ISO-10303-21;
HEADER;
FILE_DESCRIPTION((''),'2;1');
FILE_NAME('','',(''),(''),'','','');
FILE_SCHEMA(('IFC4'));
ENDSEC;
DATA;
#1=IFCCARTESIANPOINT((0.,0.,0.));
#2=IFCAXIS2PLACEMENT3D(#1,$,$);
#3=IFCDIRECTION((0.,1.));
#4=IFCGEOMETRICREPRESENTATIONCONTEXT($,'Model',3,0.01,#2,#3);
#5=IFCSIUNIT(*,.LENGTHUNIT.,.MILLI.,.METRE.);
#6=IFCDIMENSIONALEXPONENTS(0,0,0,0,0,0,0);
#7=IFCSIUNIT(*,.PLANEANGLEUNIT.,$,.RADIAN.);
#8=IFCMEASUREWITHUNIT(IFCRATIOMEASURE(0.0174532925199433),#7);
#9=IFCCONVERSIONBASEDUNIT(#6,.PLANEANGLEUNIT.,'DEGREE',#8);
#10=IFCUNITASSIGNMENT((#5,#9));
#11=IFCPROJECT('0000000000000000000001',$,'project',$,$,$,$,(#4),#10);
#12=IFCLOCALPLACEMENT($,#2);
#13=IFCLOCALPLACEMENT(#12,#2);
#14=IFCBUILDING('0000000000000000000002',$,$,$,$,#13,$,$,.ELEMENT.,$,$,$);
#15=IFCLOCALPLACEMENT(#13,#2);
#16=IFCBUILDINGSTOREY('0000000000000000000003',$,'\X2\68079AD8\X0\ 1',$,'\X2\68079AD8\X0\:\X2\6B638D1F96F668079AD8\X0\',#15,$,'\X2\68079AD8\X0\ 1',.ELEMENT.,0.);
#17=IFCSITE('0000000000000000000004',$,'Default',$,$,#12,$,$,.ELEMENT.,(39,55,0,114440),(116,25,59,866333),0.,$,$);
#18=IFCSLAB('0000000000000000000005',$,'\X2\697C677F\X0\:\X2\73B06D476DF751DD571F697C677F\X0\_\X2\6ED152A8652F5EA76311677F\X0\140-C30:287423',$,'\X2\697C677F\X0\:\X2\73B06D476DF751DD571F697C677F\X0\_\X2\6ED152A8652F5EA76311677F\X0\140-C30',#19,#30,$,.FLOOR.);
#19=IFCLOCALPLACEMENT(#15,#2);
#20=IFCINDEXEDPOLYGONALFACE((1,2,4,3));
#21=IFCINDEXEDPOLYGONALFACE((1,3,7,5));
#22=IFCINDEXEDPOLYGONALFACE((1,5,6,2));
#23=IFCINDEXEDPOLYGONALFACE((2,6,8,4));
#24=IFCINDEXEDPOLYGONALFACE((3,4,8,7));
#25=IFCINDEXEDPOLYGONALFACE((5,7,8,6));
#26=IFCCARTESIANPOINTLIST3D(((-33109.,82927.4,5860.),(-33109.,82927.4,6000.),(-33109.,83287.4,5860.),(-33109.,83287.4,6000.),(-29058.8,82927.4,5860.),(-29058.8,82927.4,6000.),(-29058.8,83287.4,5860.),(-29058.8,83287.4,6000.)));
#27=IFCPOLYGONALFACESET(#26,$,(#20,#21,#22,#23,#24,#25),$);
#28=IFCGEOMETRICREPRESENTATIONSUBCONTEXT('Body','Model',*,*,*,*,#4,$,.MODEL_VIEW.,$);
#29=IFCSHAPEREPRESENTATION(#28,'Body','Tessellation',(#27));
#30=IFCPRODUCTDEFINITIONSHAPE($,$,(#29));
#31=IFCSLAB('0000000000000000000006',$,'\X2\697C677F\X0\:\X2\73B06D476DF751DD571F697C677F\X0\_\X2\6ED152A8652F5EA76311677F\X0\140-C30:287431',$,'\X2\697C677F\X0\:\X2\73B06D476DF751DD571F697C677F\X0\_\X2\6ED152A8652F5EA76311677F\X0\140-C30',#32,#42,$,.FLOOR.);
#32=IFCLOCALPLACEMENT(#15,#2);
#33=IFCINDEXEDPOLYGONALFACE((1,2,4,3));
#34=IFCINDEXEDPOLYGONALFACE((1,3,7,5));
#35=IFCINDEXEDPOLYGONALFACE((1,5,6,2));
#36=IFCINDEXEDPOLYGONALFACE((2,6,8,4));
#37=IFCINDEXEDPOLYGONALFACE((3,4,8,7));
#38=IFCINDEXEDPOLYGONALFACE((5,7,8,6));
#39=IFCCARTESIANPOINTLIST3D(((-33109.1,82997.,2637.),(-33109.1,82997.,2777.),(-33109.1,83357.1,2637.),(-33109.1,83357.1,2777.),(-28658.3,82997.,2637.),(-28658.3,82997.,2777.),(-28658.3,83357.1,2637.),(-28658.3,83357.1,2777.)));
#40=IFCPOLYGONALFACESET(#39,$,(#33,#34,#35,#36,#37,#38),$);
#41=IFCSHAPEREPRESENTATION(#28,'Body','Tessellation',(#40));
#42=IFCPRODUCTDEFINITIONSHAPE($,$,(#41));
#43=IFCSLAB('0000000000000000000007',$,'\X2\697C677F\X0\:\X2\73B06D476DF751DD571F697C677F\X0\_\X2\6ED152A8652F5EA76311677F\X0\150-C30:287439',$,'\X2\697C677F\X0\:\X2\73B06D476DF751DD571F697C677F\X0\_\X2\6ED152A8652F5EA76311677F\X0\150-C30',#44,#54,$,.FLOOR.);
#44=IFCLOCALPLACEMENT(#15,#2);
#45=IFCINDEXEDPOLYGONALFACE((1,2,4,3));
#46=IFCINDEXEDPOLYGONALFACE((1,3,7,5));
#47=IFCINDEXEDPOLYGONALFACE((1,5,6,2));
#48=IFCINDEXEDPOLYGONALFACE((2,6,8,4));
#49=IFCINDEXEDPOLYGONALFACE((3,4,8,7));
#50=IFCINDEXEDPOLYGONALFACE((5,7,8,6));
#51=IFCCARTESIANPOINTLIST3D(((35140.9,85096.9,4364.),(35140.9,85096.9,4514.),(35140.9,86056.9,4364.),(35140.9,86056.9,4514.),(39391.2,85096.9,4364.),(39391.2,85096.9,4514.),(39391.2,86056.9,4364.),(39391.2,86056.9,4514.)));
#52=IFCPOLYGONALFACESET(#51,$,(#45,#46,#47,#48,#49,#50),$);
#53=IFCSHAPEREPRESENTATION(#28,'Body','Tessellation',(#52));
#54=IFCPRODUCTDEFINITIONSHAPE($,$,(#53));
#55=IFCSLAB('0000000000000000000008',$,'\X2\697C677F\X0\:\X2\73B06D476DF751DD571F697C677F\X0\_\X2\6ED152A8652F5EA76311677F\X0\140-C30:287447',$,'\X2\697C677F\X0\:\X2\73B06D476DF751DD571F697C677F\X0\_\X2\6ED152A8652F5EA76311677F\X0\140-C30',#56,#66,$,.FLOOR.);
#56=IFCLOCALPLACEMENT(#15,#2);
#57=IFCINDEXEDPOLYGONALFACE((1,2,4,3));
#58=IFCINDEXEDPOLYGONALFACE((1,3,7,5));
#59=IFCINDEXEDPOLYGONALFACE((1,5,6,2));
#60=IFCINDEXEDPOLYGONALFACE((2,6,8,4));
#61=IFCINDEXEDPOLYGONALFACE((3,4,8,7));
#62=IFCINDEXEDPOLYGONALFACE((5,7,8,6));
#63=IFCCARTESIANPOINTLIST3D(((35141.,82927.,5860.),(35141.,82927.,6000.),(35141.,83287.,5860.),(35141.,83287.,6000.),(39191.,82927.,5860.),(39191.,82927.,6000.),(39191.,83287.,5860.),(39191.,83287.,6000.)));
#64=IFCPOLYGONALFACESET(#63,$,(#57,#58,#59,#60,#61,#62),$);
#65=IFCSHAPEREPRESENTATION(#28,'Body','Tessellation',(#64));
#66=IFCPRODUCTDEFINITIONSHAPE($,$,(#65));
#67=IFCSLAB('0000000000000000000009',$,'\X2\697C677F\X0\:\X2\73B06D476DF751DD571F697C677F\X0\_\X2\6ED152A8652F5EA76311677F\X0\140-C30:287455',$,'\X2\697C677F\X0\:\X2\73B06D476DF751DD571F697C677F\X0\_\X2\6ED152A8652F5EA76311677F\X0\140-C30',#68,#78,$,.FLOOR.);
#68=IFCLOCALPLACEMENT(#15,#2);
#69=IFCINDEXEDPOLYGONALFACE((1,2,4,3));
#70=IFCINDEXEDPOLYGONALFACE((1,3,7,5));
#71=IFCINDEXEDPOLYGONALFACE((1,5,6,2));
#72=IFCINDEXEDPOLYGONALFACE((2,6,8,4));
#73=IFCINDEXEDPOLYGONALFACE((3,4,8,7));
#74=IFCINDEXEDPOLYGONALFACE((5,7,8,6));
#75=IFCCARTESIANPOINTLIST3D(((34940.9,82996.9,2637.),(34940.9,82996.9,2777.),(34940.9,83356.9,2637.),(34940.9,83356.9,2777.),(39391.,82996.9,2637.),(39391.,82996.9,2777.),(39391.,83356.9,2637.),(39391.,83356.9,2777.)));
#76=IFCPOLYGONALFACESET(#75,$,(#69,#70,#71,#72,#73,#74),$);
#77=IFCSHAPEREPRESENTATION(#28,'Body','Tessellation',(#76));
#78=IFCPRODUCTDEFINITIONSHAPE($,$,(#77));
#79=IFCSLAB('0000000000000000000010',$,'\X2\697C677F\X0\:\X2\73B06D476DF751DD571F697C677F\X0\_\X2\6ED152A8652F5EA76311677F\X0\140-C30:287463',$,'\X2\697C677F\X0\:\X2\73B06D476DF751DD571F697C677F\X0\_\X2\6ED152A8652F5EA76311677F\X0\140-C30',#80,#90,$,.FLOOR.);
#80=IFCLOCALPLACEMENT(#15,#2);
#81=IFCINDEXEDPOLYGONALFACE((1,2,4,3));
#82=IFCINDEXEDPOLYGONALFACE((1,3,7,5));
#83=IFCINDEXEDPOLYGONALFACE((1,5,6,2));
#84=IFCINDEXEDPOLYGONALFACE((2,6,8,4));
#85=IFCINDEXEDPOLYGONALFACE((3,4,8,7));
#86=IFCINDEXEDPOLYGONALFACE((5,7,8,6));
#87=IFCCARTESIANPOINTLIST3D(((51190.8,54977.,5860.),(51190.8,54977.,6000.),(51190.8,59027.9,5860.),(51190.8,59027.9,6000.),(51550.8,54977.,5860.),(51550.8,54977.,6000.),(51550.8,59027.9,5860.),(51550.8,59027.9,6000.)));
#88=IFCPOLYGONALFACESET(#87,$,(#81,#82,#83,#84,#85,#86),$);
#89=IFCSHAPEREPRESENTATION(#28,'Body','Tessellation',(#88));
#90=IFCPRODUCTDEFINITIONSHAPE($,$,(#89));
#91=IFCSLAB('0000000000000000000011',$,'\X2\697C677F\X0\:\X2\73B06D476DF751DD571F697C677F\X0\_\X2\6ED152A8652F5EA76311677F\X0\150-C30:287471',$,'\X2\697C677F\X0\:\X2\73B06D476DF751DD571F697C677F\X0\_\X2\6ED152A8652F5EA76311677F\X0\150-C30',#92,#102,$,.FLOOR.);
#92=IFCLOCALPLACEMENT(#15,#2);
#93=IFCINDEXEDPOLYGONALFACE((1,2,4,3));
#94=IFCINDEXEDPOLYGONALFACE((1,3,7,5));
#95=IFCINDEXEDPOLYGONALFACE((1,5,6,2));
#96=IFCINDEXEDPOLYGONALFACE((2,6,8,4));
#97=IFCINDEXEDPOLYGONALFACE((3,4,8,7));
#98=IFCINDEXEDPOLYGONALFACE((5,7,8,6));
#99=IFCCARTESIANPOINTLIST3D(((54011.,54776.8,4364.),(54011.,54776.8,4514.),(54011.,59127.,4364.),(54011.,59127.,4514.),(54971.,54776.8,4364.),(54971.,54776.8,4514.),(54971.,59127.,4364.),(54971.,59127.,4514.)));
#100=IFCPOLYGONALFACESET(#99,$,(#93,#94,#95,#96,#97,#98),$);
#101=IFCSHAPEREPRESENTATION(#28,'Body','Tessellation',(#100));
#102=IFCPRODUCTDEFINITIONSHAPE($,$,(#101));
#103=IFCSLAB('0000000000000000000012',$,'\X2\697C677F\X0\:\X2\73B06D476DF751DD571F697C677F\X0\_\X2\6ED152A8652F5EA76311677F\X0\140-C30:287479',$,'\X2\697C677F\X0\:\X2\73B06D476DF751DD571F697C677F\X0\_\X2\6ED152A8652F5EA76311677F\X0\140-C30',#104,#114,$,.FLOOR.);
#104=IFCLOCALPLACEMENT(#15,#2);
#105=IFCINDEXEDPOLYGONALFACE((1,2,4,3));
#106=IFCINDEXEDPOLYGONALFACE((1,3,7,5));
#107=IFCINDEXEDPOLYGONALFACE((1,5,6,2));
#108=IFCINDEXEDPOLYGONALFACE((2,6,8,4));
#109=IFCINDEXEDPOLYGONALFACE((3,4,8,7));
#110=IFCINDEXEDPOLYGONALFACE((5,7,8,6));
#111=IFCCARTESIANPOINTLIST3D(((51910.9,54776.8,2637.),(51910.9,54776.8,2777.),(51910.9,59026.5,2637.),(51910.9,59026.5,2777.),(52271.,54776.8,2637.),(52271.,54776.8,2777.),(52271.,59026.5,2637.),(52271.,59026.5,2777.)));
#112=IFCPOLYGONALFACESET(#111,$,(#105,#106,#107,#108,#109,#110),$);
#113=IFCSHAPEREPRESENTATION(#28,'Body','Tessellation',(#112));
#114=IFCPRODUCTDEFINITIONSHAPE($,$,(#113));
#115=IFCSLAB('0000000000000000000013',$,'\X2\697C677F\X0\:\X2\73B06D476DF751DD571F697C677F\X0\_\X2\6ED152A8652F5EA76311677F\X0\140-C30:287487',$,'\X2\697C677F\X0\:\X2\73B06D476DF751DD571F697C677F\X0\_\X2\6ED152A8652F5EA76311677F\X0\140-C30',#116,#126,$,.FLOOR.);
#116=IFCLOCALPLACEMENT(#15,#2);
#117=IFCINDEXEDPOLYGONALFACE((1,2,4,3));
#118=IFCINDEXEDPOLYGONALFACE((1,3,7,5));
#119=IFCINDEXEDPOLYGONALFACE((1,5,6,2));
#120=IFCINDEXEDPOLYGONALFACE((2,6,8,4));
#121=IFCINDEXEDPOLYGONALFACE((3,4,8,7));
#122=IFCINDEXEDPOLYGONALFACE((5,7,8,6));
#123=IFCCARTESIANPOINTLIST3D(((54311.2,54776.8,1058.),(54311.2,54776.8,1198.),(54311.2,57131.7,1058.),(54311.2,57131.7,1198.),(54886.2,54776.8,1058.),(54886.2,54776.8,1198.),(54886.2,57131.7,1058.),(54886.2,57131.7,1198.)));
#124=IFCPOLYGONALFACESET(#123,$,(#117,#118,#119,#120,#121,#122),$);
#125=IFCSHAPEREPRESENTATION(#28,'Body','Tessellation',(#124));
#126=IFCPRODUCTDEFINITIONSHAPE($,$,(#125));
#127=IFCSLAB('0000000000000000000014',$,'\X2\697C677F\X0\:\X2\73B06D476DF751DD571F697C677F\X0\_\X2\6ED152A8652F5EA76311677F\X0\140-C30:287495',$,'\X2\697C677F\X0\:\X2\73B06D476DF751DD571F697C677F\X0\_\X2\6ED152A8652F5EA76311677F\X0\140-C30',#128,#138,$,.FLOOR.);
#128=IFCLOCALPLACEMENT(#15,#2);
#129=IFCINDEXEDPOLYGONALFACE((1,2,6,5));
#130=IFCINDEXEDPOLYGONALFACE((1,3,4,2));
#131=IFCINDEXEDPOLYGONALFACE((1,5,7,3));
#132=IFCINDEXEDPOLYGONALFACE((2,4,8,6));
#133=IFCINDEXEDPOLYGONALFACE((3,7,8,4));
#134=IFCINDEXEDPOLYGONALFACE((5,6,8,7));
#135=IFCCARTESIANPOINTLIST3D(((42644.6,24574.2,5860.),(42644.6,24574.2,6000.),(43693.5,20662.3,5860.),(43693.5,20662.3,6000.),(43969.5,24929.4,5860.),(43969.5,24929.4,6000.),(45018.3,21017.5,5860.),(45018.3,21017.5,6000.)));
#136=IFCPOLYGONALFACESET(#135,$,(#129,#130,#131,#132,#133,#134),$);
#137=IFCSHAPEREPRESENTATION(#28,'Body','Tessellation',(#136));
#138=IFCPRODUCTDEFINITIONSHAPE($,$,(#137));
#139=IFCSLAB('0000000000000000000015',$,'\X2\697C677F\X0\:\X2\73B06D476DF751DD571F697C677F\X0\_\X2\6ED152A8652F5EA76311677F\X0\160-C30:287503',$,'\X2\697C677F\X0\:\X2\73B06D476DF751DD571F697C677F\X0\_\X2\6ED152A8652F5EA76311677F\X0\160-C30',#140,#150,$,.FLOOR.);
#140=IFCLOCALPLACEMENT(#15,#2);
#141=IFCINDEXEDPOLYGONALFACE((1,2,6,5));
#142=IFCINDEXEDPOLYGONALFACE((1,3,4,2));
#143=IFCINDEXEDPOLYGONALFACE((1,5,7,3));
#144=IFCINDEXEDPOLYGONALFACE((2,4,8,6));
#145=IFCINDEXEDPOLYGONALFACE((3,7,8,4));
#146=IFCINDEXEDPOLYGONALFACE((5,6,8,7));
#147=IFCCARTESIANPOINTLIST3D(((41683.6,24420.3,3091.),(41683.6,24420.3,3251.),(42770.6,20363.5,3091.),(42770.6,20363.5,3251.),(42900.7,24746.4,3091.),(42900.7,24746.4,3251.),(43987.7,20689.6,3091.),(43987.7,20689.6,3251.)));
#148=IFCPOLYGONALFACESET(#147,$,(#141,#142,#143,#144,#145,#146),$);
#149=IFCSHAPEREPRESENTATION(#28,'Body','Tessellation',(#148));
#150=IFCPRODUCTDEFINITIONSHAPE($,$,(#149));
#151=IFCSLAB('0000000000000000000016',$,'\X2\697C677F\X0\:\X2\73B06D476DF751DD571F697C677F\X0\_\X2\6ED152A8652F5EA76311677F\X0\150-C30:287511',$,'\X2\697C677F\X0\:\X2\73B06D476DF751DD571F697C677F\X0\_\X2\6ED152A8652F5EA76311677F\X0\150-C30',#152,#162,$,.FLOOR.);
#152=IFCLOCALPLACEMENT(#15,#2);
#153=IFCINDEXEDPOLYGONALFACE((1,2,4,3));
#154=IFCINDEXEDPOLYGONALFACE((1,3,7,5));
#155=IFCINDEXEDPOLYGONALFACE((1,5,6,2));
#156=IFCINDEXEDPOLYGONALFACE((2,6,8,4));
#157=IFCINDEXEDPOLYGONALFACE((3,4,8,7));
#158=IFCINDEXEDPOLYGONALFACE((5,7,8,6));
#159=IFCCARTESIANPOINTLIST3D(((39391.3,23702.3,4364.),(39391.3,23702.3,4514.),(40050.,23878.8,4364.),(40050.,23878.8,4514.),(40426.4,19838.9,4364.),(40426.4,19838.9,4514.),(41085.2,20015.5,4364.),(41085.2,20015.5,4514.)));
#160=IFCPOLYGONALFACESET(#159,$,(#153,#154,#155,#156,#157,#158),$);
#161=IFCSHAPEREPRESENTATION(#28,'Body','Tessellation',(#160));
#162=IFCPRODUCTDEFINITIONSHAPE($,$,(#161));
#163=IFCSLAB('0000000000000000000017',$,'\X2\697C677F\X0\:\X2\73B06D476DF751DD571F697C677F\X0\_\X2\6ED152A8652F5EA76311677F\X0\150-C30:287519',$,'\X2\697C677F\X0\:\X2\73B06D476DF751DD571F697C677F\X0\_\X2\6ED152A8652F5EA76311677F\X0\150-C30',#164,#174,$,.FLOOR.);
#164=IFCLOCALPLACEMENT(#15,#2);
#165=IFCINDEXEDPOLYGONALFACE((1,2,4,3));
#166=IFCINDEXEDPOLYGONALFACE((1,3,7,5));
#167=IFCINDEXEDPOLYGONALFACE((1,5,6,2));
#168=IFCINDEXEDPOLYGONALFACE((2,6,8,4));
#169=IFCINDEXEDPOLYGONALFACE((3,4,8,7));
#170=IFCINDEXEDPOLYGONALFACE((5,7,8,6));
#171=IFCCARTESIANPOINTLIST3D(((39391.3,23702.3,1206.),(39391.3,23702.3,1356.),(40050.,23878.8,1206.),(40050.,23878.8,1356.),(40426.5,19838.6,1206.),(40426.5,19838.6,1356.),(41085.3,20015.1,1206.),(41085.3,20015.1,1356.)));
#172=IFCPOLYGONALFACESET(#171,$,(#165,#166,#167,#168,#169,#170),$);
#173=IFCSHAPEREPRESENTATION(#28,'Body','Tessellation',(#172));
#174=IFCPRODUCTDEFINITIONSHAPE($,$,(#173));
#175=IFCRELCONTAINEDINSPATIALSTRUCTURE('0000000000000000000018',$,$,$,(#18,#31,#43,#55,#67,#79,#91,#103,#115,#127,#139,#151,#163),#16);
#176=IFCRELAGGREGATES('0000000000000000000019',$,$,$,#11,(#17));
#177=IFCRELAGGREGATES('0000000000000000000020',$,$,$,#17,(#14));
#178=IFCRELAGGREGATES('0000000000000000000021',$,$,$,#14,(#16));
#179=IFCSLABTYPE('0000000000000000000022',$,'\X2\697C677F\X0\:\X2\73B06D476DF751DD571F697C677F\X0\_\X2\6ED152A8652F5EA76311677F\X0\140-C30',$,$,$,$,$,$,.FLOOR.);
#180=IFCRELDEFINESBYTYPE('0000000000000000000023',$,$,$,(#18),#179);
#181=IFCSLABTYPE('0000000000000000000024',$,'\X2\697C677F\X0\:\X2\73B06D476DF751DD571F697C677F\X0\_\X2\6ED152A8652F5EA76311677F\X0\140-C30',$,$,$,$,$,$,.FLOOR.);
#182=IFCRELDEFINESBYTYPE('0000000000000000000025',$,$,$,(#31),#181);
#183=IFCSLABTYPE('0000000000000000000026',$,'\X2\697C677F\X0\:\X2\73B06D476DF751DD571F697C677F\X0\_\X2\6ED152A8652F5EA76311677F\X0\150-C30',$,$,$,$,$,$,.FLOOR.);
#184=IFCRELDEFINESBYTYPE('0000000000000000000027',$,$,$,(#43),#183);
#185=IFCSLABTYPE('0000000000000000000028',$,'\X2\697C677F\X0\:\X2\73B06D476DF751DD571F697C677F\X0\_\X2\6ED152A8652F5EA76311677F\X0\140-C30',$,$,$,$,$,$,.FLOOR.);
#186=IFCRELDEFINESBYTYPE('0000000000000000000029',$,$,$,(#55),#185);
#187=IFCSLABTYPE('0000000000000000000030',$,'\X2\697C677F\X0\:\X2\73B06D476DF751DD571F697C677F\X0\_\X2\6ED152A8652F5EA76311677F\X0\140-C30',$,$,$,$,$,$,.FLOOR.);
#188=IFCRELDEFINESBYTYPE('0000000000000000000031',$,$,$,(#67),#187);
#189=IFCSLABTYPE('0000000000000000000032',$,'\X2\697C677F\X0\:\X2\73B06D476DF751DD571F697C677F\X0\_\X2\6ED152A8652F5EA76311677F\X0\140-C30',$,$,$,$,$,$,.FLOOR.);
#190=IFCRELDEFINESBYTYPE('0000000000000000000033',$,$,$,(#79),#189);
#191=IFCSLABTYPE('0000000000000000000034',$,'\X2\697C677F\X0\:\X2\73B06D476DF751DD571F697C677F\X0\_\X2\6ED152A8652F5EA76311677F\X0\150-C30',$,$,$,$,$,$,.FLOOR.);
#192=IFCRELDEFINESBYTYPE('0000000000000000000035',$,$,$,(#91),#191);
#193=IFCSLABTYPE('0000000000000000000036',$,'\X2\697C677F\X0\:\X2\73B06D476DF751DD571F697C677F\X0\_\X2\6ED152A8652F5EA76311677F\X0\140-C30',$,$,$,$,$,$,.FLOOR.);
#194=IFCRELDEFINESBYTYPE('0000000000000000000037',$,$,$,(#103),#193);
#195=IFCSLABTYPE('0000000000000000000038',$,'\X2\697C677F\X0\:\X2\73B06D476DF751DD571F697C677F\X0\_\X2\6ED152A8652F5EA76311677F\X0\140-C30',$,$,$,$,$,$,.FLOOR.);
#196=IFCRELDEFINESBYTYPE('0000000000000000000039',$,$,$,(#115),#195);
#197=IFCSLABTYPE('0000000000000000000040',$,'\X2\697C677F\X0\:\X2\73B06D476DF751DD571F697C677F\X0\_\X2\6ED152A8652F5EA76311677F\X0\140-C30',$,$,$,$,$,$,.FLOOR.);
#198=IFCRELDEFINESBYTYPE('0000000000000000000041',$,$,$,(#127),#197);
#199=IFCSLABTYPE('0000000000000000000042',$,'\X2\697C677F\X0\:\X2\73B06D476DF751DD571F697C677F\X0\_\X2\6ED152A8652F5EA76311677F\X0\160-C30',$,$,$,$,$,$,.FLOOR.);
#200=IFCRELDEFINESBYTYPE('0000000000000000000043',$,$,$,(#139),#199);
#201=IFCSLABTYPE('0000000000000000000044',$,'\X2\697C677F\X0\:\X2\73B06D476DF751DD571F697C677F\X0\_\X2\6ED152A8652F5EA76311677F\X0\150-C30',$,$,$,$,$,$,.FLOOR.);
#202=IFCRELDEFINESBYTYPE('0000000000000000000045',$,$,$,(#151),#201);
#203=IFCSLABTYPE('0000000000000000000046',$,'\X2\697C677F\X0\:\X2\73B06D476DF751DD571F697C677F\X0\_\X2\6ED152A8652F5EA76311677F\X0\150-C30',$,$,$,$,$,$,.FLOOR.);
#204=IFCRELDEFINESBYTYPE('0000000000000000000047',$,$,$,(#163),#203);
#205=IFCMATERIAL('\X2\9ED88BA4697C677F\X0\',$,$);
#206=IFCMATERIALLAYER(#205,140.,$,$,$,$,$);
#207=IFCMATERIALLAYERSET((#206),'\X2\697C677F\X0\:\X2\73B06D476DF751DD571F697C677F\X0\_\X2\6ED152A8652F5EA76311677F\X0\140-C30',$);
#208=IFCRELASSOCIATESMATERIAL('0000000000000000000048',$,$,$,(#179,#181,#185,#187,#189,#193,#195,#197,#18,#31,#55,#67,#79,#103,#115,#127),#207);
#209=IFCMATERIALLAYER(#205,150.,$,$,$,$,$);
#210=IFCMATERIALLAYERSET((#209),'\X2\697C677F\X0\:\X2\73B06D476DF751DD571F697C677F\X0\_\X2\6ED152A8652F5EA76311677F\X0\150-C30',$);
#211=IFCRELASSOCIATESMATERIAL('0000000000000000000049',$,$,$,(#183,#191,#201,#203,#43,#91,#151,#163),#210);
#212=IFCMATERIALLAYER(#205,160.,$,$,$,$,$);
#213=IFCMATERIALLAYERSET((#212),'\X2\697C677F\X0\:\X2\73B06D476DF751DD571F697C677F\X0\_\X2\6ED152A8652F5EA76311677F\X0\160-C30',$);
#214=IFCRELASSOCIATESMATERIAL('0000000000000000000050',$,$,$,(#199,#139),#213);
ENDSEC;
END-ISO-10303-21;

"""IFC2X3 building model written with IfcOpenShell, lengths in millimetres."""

from ifc_helpers import new_model, entity, si_unit, converted_unit, direction, frame, frame_2d, origin, origin_2d_with_axis, place, context, subcontext, project, spatial, polyline, rectangle, outline, extrude, material, layer, layer_set, layer_usage, type_object, element, save


model = new_model("IFC2X3")

# Units and contexts
model_context = context("Model", 3, precision=0.01, world=origin(), true_north=direction((0.0, 1.0)))
body_context = subcontext(model_context, "Body", "Model", "MODEL_VIEW")
ifc_project = project(units=[si_unit("LENGTHUNIT", "METRE", prefix="MILLI"), converted_unit("PLANEANGLEUNIT", "DEGREE", entity("IfcRatioMeasure", 0.0174532925199433), si_unit("PLANEANGLEUNIT", "RADIAN"), dimensions=[0, 0, 0, 0, 0, 0, 0])], contexts=[model_context])

# Site, building, storey
site_placement = place(None, origin())
site = spatial("IfcSite", under=ifc_project, at=site_placement, Name="Default", CompositionType="ELEMENT", RefLatitude=(39, 55, 0, 114440), RefLongitude=(116, 25, 59, 866333), RefElevation=0.0)
building_placement = place(site_placement, origin())
building = spatial("IfcBuilding", under=site, at=building_placement, CompositionType="ELEMENT")
storey_placement = place(building_placement, origin())
storey = spatial("IfcBuildingStorey", under=building, at=storey_placement, Name="标高 1", ObjectType="标高:正负零标高", LongName="标高 1", CompositionType="ELEMENT", Elevation=0.0)

# Slabs
ifc_material = material(Name="默认楼板")
ifc_layer_1 = layer(ifc_material, 140.0)
ifc_layer_set_1 = layer_set([ifc_layer_1], Name="楼板:现浇混凝土楼板_滑动支座挑板140-C30")
ifc_layer_usage_1 = layer_usage(ifc_layer_set_1, "AXIS3", "POSITIVE", 0.0)
slab_type_1 = type_object("IfcSlabType", Name="楼板:现浇混凝土楼板_滑动支座挑板140-C30", PredefinedType="FLOOR", material=ifc_layer_set_1)
slab_1_placement = place(building_placement, origin())
element("IfcSlab", 1, at=slab_1_placement, inside=storey, type_object=slab_type_1, material=ifc_layer_usage_1, Name="楼板:现浇混凝土楼板_滑动支座挑板140-C30:287423", ObjectType="楼板:现浇混凝土楼板_滑动支座挑板140-C30", PredefinedType="FLOOR", context=body_context, shape_type="SweptSolid", body=[
    extrude(rectangle(XDim=360.0, YDim=4050.2, at=frame_2d((0.0, 0.0), x_axis=(1.0, 0.0))), frame((-31083.9, 83107.4, 6000.0), z_axis=(0.0, 0.0, -1.0), x_axis=(0.0, 1.0, 0.0)), (0.0, 0.0, 1.0), 140.0),
])
ifc_layer_usage_2 = layer_usage(ifc_layer_set_1, "AXIS3", "POSITIVE", 0.0)
slab_type_2 = type_object("IfcSlabType", Name="楼板:现浇混凝土楼板_滑动支座挑板140-C30", PredefinedType="FLOOR", material=ifc_layer_set_1)
slab_2_placement = place(building_placement, origin())
element("IfcSlab", 2, at=slab_2_placement, inside=storey, type_object=slab_type_2, material=ifc_layer_usage_2, Name="楼板:现浇混凝土楼板_滑动支座挑板140-C30:287431", ObjectType="楼板:现浇混凝土楼板_滑动支座挑板140-C30", PredefinedType="FLOOR", context=body_context, shape_type="SweptSolid", body=[
    extrude(rectangle(XDim=360.2, YDim=4450.8, at=frame_2d((0.0, 0.0), x_axis=(1.0, 0.0))), frame((-30883.7, 83177.0, 2777.0), z_axis=(0.0, 0.0, -1.0), x_axis=(0.0, 1.0, 0.0)), (0.0, 0.0, 1.0), 140.0),
])
ifc_layer_2 = layer(ifc_material, 150.0)
ifc_layer_set_2 = layer_set([ifc_layer_2], Name="楼板:现浇混凝土楼板_滑动支座挑板150-C30")
ifc_layer_usage_3 = layer_usage(ifc_layer_set_2, "AXIS3", "POSITIVE", 0.0)
slab_type_3 = type_object("IfcSlabType", Name="楼板:现浇混凝土楼板_滑动支座挑板150-C30", PredefinedType="FLOOR", material=ifc_layer_set_2)
slab_3_placement = place(building_placement, origin())
element("IfcSlab", 3, at=slab_3_placement, inside=storey, type_object=slab_type_3, material=ifc_layer_usage_3, Name="楼板:现浇混凝土楼板_滑动支座挑板150-C30:287439", ObjectType="楼板:现浇混凝土楼板_滑动支座挑板150-C30", PredefinedType="FLOOR", context=body_context, shape_type="SweptSolid", body=[
    extrude(rectangle(XDim=960.0, YDim=4250.3, at=frame_2d((0.0, 0.0), x_axis=(1.0, 0.0))), frame((37266.0, 85576.9, 4514.0), z_axis=(0.0, 0.0, -1.0), x_axis=(0.0, 1.0, 0.0)), (0.0, 0.0, 1.0), 150.0),
])
ifc_layer_usage_4 = layer_usage(ifc_layer_set_1, "AXIS3", "POSITIVE", 0.0)
slab_type_4 = type_object("IfcSlabType", Name="楼板:现浇混凝土楼板_滑动支座挑板140-C30", PredefinedType="FLOOR", material=ifc_layer_set_1)
slab_4_placement = place(building_placement, origin())
element("IfcSlab", 4, at=slab_4_placement, inside=storey, type_object=slab_type_4, material=ifc_layer_usage_4, Name="楼板:现浇混凝土楼板_滑动支座挑板140-C30:287447", ObjectType="楼板:现浇混凝土楼板_滑动支座挑板140-C30", PredefinedType="FLOOR", context=body_context, shape_type="SweptSolid", body=[
    extrude(rectangle(XDim=360.0, YDim=4050.0, at=origin_2d_with_axis()), frame((37166.0, 83107.0, 6000.0), z_axis=(0.0, 0.0, -1.0), x_axis=(0.0, 1.0, 0.0)), (0.0, 0.0, 1.0), 140.0),
])
ifc_layer_usage_5 = layer_usage(ifc_layer_set_1, "AXIS3", "POSITIVE", 0.0)
slab_type_5 = type_object("IfcSlabType", Name="楼板:现浇混凝土楼板_滑动支座挑板140-C30", PredefinedType="FLOOR", material=ifc_layer_set_1)
slab_5_placement = place(building_placement, origin())
element("IfcSlab", 5, at=slab_5_placement, inside=storey, type_object=slab_type_5, material=ifc_layer_usage_5, Name="楼板:现浇混凝土楼板_滑动支座挑板140-C30:287455", ObjectType="楼板:现浇混凝土楼板_滑动支座挑板140-C30", PredefinedType="FLOOR", context=body_context, shape_type="SweptSolid", body=[
    extrude(rectangle(XDim=360.0, YDim=4450.1, at=frame_2d((0.0, 0.0), x_axis=(1.0, 0.0))), frame((37165.9, 83176.9, 2777.0), z_axis=(0.0, 0.0, -1.0), x_axis=(0.0, 1.0, 0.0)), (0.0, 0.0, 1.0), 140.0),
])
ifc_layer_usage_6 = layer_usage(ifc_layer_set_1, "AXIS3", "POSITIVE", 0.0)
slab_type_6 = type_object("IfcSlabType", Name="楼板:现浇混凝土楼板_滑动支座挑板140-C30", PredefinedType="FLOOR", material=ifc_layer_set_1)
slab_6_placement = place(building_placement, origin())
element("IfcSlab", 6, at=slab_6_placement, inside=storey, type_object=slab_type_6, material=ifc_layer_usage_6, Name="楼板:现浇混凝土楼板_滑动支座挑板140-C30:287463", ObjectType="楼板:现浇混凝土楼板_滑动支座挑板140-C30", PredefinedType="FLOOR", context=body_context, shape_type="SweptSolid", body=[
    extrude(rectangle(XDim=4050.9, YDim=360.0, at=frame_2d((0.0, 0.0), x_axis=(1.0, 0.0))), frame((51370.8, 57002.4, 6000.0), z_axis=(0.0, 0.0, -1.0), x_axis=(0.0, 1.0, 0.0)), (0.0, 0.0, 1.0), 140.0),
])
ifc_layer_usage_7 = layer_usage(ifc_layer_set_2, "AXIS3", "POSITIVE", 0.0)
slab_type_7 = type_object("IfcSlabType", Name="楼板:现浇混凝土楼板_滑动支座挑板150-C30", PredefinedType="FLOOR", material=ifc_layer_set_2)
slab_7_placement = place(building_placement, origin())
element("IfcSlab", 7, at=slab_7_placement, inside=storey, type_object=slab_type_7, material=ifc_layer_usage_7, Name="楼板:现浇混凝土楼板_滑动支座挑板150-C30:287471", ObjectType="楼板:现浇混凝土楼板_滑动支座挑板150-C30", PredefinedType="FLOOR", context=body_context, shape_type="SweptSolid", body=[
    extrude(rectangle(XDim=4350.2, YDim=960.0, at=origin_2d_with_axis()), frame((54491.0, 56951.9, 4514.0), z_axis=(0.0, 0.0, -1.0), x_axis=(0.0, 1.0, 0.0)), (0.0, 0.0, 1.0), 150.0),
])
ifc_layer_usage_8 = layer_usage(ifc_layer_set_1, "AXIS3", "POSITIVE", 0.0)
slab_type_8 = type_object("IfcSlabType", Name="楼板:现浇混凝土楼板_滑动支座挑板140-C30", PredefinedType="FLOOR", material=ifc_layer_set_1)
slab_8_placement = place(building_placement, origin())
element("IfcSlab", 8, at=slab_8_placement, inside=storey, type_object=slab_type_8, material=ifc_layer_usage_8, Name="楼板:现浇混凝土楼板_滑动支座挑板140-C30:287479", ObjectType="楼板:现浇混凝土楼板_滑动支座挑板140-C30", PredefinedType="FLOOR", context=body_context, shape_type="SweptSolid", body=[
    extrude(rectangle(XDim=4249.7, YDim=360.1, at=frame_2d((0.0, 0.0), x_axis=(1.0, 0.0))), frame((52091.0, 56901.7, 2777.0), z_axis=(0.0, 0.0, -1.0), x_axis=(0.0, 1.0, 0.0)), (0.0, 0.0, 1.0), 140.0),
])
ifc_layer_usage_9 = layer_usage(ifc_layer_set_1, "AXIS3", "POSITIVE", 0.0)
slab_type_9 = type_object("IfcSlabType", Name="楼板:现浇混凝土楼板_滑动支座挑板140-C30", PredefinedType="FLOOR", material=ifc_layer_set_1)
slab_9_placement = place(building_placement, origin())
element("IfcSlab", 9, at=slab_9_placement, inside=storey, type_object=slab_type_9, material=ifc_layer_usage_9, Name="楼板:现浇混凝土楼板_滑动支座挑板140-C30:287487", ObjectType="楼板:现浇混凝土楼板_滑动支座挑板140-C30", PredefinedType="FLOOR", context=body_context, shape_type="SweptSolid", body=[
    extrude(rectangle(XDim=2354.8, YDim=575.0, at=frame_2d((0.0, 0.0), x_axis=(1.0, 0.0))), frame((54598.7, 55954.2, 1198.0), z_axis=(0.0, 0.0, -1.0), x_axis=(0.0, 1.0, 0.0)), (0.0, 0.0, 1.0), 140.0),
])
ifc_layer_usage_10 = layer_usage(ifc_layer_set_1, "AXIS3", "POSITIVE", 0.0)
slab_type_10 = type_object("IfcSlabType", Name="楼板:现浇混凝土楼板_滑动支座挑板140-C30", PredefinedType="FLOOR", material=ifc_layer_set_1)
slab_10_placement = place(building_placement, origin())
element("IfcSlab", 10, at=slab_10_placement, inside=storey, type_object=slab_type_10, material=ifc_layer_usage_10, Name="楼板:现浇混凝土楼板_滑动支座挑板140-C30:287495", ObjectType="楼板:现浇混凝土楼板_滑动支座挑板140-C30", PredefinedType="FLOOR", context=body_context, shape_type="SweptSolid", body=[
    extrude(rectangle(XDim=4050.1, YDim=1371.6, at=frame_2d((0.0, 0.0), x_axis=(1.0, 0.0))), frame((43831.5, 22795.9, 6000.0), z_axis=(0.0, 0.0, -1.0), x_axis=(0.258967, -0.965886, 0.0)), (0.0, 0.0, 1.0), 140.0),
])
ifc_layer_3 = layer(ifc_material, 160.0)
ifc_layer_set_3 = layer_set([ifc_layer_3], Name="楼板:现浇混凝土楼板_滑动支座挑板160-C30")
ifc_layer_usage_11 = layer_usage(ifc_layer_set_3, "AXIS3", "POSITIVE", 0.0)
slab_type_11 = type_object("IfcSlabType", Name="楼板:现浇混凝土楼板_滑动支座挑板160-C30", PredefinedType="FLOOR", material=ifc_layer_set_3)
slab_11_placement = place(building_placement, origin())
element("IfcSlab", 11, at=slab_11_placement, inside=storey, type_object=slab_type_11, material=ifc_layer_usage_11, Name="楼板:现浇混凝土楼板_滑动支座挑板160-C30:287503", ObjectType="楼板:现浇混凝土楼板_滑动支座挑板160-C30", PredefinedType="FLOOR", context=body_context, shape_type="SweptSolid", body=[
    extrude(outline(polyline([(-2100.0, -630.0), (2100.0, -630.0), (2100.0, 630.0), (-2100.0, 630.0), (-2100.0, -630.0)])), frame((42835.6, 22554.9, 3251.0), z_axis=(0.0, 0.0, -1.0), x_axis=(0.258822, -0.965925, 0.0)), (0.0, 0.0, 1.0), 160.0),
])
ifc_layer_usage_12 = layer_usage(ifc_layer_set_2, "AXIS3", "POSITIVE", 0.0)
slab_type_12 = type_object("IfcSlabType", Name="楼板:现浇混凝土楼板_滑动支座挑板150-C30", PredefinedType="FLOOR", material=ifc_layer_set_2)
slab_12_placement = place(building_placement, origin())
element("IfcSlab", 12, at=slab_12_placement, inside=storey, type_object=slab_type_12, material=ifc_layer_usage_12, Name="楼板:现浇混凝土楼板_滑动支座挑板150-C30:287511", ObjectType="楼板:现浇混凝土楼板_滑动支座挑板150-C30", PredefinedType="FLOOR", context=body_context, shape_type="SweptSolid", body=[
    extrude(outline(polyline([(-1999.8, -341.0), (1999.8, -341.0), (1999.8, 341.0), (-1999.8, 341.0), (-1999.8, -341.0)])), frame((40238.2, 21858.9, 4514.0), z_axis=(0.0, 0.0, -1.0), x_axis=(0.25882, -0.965926, 0.0)), (0.0, 0.0, 1.0), 150.0),
])
ifc_layer_usage_13 = layer_usage(ifc_layer_set_2, "AXIS3", "POSITIVE", 0.0)
slab_type_13 = type_object("IfcSlabType", Name="楼板:现浇混凝土楼板_滑动支座挑板150-C30", PredefinedType="FLOOR", material=ifc_layer_set_2)
slab_13_placement = place(building_placement, origin())
element("IfcSlab", 13, at=slab_13_placement, inside=storey, type_object=slab_type_13, material=ifc_layer_usage_13, Name="楼板:现浇混凝土楼板_滑动支座挑板150-C30:287519", ObjectType="楼板:现浇混凝土楼板_滑动支座挑板150-C30", PredefinedType="FLOOR", context=body_context, shape_type="SweptSolid", body=[
    extrude(outline(polyline([(-2000.0, -341.0), (2000.0, -341.0), (2000.0, 341.0), (-2000.0, 341.0), (-2000.0, -341.0)])), frame((40238.3, 21858.7, 1356.0), z_axis=(0.0, 0.0, -1.0), x_axis=(0.25882, -0.965926, 0.0)), (0.0, 0.0, 1.0), 150.0),
])

save(model, "model.ifc")
